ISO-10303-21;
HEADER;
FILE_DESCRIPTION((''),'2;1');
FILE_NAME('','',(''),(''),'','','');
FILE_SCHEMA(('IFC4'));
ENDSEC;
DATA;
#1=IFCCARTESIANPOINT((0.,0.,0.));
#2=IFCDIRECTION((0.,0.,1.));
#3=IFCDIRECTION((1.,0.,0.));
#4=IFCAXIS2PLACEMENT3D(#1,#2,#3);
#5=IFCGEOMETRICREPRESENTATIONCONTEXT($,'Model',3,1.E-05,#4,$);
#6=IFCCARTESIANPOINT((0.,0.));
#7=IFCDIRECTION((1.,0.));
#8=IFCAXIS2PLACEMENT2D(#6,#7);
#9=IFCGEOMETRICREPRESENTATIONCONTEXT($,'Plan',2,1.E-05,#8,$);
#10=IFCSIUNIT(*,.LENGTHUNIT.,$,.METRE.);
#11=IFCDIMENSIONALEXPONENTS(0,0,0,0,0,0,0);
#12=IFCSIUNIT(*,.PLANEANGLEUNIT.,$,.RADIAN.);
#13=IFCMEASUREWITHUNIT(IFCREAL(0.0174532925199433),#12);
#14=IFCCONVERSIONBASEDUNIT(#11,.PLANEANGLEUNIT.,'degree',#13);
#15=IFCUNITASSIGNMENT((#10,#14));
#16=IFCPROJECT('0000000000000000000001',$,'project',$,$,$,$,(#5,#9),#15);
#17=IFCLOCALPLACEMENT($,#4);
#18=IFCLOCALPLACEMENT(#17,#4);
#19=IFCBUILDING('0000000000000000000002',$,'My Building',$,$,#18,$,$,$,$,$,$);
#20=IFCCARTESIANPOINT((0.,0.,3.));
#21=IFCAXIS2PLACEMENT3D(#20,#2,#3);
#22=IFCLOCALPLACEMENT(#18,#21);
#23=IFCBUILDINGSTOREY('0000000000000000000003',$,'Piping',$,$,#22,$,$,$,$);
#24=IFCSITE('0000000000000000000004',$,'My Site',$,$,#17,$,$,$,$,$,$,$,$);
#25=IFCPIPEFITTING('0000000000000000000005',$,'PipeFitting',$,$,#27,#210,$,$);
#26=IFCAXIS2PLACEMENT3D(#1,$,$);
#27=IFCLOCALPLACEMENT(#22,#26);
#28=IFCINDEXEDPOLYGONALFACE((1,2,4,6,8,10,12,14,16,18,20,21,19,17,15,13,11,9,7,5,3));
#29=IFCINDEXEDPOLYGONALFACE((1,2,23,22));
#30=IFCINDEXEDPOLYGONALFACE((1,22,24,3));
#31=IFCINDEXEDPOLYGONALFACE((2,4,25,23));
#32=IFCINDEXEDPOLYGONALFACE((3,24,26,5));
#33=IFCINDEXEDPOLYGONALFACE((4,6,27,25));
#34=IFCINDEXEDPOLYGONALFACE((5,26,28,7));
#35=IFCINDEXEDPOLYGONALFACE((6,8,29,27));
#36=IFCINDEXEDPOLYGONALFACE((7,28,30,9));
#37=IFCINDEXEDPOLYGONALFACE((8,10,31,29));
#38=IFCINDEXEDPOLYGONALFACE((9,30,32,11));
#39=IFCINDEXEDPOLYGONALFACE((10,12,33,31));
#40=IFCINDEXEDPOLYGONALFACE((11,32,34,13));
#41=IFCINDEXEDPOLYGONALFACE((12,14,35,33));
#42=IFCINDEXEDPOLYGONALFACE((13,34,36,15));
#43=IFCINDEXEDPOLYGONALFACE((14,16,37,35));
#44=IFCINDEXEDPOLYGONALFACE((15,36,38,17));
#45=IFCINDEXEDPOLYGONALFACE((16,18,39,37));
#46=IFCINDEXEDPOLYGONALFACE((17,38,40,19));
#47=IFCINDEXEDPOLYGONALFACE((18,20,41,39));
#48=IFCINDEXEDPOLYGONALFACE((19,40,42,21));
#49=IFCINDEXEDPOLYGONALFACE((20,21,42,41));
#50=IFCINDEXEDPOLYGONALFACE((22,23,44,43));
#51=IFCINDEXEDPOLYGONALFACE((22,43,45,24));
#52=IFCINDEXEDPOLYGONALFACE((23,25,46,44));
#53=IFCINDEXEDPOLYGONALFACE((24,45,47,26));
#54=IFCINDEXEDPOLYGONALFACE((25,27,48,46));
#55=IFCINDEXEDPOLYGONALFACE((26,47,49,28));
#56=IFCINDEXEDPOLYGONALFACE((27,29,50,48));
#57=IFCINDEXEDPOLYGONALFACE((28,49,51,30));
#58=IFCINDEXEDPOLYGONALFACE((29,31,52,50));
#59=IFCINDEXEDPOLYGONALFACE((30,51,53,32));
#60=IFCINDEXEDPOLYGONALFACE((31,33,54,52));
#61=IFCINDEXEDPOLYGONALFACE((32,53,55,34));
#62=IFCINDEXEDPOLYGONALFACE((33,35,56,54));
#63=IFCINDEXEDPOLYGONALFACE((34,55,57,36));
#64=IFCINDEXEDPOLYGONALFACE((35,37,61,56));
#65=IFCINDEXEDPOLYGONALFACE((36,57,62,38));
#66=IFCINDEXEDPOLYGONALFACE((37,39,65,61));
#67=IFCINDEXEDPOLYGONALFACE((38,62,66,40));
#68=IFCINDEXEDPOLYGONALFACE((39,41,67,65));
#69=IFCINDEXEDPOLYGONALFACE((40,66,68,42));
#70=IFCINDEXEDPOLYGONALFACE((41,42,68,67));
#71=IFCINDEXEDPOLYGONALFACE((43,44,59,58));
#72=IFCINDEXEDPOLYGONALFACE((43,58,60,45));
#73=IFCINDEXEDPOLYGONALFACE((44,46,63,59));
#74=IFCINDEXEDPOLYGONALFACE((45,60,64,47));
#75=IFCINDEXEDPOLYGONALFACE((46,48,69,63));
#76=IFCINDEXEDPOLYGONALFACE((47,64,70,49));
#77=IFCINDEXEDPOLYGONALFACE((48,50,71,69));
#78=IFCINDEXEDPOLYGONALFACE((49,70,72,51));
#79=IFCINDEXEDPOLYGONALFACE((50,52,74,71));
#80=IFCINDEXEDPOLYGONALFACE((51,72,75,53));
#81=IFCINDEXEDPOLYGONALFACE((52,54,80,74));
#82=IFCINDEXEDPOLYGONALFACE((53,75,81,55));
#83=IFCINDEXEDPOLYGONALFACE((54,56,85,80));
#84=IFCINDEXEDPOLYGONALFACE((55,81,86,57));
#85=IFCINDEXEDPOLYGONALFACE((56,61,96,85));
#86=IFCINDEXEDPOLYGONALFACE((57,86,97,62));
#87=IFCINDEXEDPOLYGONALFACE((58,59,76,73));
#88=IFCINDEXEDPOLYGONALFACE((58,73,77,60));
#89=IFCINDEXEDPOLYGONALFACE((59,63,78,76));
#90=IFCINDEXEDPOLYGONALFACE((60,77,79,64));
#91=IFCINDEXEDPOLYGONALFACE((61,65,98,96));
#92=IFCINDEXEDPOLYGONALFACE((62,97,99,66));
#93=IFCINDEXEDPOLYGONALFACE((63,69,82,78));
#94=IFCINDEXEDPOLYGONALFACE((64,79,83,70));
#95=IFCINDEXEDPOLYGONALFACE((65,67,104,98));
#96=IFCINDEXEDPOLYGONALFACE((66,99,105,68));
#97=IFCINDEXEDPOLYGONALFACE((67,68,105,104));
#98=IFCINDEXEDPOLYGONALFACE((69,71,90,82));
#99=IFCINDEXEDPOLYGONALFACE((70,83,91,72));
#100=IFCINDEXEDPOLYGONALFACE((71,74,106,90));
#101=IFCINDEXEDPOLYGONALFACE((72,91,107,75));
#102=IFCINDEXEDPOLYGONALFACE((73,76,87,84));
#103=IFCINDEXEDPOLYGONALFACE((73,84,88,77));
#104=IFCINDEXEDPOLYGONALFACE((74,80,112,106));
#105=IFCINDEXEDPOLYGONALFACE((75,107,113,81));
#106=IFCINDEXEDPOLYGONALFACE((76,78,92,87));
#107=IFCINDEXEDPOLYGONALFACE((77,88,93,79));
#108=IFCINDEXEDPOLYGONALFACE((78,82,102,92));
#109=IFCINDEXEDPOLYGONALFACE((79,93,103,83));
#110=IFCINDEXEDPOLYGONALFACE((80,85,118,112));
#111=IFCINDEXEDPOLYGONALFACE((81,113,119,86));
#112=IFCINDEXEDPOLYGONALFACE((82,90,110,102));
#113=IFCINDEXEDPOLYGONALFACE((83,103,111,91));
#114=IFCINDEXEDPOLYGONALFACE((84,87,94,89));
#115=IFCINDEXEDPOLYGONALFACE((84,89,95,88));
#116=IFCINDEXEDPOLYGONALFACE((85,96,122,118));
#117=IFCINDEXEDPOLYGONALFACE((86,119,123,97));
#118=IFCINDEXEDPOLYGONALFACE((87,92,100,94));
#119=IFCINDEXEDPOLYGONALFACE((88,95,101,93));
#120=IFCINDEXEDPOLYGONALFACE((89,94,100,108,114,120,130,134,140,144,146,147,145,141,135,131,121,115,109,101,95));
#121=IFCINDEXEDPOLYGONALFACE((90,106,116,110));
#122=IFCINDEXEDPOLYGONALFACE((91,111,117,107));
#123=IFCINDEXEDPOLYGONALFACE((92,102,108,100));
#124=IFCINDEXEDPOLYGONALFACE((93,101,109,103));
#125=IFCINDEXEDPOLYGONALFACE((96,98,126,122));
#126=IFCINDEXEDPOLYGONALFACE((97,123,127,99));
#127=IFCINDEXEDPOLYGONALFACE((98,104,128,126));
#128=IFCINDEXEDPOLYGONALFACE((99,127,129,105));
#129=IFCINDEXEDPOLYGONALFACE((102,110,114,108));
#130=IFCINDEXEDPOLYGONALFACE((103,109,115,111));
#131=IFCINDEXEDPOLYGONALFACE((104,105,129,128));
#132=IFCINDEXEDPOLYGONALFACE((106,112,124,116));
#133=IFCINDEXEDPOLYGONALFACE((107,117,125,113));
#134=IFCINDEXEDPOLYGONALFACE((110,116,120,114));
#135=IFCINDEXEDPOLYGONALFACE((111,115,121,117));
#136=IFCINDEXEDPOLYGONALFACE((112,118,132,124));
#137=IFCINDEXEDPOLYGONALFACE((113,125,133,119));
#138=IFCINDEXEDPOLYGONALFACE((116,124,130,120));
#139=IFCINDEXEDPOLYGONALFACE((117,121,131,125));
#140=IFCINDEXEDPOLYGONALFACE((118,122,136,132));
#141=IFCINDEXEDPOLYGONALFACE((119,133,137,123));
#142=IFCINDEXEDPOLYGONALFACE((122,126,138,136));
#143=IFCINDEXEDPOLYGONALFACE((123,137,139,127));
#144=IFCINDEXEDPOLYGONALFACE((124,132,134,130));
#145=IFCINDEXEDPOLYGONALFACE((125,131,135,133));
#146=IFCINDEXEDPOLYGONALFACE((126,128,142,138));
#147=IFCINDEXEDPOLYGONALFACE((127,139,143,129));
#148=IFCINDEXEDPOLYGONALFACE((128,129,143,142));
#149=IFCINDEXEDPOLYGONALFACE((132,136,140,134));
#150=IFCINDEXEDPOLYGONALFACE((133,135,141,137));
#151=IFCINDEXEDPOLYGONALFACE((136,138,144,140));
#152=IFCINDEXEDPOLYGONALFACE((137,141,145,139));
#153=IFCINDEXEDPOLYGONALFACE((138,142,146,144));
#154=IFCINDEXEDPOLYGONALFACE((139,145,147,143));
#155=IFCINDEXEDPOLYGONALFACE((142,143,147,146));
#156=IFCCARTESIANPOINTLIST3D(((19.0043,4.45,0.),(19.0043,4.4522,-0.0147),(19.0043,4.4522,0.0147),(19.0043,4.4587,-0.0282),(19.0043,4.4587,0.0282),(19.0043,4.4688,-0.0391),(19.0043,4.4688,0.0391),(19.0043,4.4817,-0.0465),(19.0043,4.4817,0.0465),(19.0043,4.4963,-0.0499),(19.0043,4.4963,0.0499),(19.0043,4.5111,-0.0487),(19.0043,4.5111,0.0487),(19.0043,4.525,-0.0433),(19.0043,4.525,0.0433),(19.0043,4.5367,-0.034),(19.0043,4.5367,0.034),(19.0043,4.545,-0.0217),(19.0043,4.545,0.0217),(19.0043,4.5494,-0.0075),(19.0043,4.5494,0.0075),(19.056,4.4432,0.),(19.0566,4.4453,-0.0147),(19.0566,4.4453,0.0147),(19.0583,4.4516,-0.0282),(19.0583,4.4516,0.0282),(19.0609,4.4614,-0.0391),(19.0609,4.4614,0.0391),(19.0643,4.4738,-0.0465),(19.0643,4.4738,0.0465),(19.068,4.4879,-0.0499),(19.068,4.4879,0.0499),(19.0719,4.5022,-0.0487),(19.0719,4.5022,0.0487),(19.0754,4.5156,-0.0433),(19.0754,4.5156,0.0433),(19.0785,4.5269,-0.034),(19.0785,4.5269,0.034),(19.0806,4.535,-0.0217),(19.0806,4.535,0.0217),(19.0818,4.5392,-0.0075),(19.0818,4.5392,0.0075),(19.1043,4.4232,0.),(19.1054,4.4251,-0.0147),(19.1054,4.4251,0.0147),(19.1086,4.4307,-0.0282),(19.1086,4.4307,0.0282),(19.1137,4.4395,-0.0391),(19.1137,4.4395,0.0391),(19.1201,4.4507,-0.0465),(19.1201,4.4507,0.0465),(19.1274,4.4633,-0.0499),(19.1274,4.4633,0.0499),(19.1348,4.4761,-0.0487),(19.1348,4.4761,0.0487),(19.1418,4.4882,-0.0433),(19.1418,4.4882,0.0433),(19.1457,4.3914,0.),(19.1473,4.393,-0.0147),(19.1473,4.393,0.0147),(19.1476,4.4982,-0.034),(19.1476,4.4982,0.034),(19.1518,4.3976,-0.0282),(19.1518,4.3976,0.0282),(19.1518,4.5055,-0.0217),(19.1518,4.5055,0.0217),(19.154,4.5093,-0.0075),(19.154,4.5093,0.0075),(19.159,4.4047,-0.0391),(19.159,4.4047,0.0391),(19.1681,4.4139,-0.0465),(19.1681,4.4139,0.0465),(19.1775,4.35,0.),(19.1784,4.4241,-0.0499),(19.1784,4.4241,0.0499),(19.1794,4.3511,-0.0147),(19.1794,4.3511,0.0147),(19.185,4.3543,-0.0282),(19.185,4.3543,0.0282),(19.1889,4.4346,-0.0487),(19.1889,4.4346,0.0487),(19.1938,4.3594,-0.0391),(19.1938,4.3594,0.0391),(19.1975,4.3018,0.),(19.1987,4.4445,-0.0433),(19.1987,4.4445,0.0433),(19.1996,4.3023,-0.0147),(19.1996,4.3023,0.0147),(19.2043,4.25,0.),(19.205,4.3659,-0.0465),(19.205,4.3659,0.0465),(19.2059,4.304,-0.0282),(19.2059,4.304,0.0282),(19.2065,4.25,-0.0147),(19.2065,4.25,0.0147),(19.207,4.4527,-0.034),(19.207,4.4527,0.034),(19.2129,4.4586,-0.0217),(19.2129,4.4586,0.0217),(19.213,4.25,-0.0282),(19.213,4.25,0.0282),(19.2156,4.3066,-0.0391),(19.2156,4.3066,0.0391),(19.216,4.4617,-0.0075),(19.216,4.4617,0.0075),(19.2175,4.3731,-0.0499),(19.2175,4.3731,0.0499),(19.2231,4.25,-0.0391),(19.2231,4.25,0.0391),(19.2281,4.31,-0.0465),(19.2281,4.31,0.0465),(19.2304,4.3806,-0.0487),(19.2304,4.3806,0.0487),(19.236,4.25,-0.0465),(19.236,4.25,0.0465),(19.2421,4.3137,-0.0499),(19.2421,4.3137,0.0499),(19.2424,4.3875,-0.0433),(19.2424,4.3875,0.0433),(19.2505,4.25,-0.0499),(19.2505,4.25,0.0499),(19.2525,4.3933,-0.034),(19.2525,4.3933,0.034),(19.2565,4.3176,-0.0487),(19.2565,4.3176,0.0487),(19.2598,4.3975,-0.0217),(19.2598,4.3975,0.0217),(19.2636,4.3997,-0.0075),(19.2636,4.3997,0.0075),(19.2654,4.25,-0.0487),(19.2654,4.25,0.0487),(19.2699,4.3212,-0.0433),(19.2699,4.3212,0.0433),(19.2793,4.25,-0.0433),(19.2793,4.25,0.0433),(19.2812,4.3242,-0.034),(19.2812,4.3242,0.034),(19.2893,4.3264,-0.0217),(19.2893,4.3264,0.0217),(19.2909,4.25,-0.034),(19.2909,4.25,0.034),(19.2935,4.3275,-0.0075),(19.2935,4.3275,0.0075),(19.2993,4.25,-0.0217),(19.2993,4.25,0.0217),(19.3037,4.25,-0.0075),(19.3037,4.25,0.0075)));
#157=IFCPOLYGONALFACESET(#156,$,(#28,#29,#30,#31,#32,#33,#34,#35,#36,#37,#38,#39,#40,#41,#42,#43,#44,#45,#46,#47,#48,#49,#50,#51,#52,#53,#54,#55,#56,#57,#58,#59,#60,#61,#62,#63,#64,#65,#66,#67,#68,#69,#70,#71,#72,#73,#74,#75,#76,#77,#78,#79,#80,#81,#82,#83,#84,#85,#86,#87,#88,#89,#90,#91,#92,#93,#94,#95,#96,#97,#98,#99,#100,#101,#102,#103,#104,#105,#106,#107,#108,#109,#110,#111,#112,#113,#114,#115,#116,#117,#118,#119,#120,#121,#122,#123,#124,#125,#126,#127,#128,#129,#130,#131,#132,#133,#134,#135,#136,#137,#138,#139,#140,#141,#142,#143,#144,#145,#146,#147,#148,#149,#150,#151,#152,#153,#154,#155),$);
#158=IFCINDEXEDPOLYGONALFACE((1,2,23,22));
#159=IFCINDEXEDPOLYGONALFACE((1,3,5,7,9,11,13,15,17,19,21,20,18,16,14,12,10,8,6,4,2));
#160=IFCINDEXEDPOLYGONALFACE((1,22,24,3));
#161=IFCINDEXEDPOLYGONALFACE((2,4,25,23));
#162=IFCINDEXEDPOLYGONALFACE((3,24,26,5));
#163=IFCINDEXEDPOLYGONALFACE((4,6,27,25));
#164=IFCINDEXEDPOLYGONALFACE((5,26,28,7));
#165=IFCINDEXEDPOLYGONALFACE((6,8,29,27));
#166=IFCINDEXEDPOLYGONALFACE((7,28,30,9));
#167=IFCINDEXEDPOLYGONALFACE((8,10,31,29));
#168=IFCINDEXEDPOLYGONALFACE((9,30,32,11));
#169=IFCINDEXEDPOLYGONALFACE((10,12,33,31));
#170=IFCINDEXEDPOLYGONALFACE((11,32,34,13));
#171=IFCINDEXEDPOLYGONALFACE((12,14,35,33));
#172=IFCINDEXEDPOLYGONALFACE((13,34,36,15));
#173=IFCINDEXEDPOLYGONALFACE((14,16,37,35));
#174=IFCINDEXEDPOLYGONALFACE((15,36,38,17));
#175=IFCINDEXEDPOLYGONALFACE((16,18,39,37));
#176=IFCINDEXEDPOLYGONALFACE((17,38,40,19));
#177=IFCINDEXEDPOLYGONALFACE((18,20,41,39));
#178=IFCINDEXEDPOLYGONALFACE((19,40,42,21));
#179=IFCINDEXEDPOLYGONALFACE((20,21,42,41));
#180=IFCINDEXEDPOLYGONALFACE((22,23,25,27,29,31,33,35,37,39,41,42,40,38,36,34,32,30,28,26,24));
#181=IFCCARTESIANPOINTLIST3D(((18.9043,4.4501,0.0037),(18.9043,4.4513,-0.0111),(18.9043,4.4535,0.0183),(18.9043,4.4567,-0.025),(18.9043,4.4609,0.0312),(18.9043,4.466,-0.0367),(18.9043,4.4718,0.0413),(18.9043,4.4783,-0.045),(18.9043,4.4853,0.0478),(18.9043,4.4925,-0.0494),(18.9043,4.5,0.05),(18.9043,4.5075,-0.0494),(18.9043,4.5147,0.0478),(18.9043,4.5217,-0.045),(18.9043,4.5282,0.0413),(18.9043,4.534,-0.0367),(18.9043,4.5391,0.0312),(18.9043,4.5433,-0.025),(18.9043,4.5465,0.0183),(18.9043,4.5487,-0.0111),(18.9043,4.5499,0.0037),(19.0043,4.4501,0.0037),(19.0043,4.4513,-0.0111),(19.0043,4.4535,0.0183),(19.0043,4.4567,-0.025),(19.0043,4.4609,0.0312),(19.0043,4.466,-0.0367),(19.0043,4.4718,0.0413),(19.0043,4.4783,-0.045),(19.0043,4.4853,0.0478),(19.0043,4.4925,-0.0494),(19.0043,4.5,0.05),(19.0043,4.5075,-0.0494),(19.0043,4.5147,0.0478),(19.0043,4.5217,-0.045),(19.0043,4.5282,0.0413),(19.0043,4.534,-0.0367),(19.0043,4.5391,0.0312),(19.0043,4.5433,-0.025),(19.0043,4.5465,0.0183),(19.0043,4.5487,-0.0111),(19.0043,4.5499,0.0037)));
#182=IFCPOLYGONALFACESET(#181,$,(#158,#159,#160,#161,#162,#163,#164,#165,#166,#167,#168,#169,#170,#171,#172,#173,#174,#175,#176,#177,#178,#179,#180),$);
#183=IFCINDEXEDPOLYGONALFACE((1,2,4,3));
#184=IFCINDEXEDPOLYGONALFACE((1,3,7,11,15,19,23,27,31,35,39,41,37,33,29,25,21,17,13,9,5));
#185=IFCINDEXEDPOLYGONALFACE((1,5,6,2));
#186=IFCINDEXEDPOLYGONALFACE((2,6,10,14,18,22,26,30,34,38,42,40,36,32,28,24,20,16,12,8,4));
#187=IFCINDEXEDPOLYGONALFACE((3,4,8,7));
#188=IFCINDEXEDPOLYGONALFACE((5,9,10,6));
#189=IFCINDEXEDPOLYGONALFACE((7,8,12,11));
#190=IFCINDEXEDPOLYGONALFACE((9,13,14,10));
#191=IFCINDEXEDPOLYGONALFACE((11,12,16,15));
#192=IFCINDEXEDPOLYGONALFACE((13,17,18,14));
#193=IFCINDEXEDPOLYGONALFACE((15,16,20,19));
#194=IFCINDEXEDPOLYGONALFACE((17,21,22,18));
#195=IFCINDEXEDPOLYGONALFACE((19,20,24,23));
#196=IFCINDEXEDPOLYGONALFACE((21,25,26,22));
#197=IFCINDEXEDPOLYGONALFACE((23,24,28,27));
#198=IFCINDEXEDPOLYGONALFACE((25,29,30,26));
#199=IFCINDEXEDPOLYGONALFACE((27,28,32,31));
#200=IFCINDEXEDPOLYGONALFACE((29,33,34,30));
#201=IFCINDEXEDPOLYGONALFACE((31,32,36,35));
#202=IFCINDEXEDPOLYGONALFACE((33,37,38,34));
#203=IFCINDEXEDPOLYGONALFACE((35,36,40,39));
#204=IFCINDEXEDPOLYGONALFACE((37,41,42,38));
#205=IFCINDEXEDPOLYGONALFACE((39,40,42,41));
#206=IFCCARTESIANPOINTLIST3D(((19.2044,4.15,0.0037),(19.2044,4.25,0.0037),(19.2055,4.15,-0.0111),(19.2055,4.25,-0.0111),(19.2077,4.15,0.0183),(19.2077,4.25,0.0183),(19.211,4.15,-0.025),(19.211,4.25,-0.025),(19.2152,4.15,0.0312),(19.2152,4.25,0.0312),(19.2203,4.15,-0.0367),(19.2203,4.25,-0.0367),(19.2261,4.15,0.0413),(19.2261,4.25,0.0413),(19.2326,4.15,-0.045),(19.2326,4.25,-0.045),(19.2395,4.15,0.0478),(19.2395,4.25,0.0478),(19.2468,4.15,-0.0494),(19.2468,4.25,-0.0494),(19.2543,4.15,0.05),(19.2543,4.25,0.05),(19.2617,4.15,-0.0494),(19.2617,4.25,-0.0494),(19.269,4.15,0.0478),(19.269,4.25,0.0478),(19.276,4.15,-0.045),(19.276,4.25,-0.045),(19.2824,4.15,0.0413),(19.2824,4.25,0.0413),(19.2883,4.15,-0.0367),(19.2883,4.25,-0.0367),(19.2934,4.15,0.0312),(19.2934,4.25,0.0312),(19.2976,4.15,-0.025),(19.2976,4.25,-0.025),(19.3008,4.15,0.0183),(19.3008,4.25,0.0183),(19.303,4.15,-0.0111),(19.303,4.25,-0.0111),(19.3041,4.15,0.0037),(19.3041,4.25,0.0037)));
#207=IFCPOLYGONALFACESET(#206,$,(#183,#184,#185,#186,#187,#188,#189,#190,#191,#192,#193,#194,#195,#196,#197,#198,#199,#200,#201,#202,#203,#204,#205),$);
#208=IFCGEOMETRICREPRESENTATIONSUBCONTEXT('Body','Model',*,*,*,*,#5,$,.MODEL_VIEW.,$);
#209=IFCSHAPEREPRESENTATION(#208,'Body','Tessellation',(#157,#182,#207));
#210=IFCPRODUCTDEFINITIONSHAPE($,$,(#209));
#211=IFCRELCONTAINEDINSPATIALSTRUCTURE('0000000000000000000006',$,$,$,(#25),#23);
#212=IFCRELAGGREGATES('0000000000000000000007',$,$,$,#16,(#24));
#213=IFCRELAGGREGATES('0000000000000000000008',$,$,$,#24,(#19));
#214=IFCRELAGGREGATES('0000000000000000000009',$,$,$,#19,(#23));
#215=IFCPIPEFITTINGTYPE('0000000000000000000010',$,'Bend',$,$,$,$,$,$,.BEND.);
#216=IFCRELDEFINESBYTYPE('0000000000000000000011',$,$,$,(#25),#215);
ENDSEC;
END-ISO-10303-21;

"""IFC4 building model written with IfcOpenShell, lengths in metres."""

from ifc_helpers import new_model, entity, si_unit, converted_unit, frame, origin_with_axes, origin_2d_with_axis, place, context, subcontext, project, spatial, circle, extrude, source, transform, mapped, type_object, type_shapes, element, save


model = new_model("IFC4")

# Units and contexts
model_context = context("Model", 3, precision=1e-05, world=origin_with_axes())
plan_context = context("Plan", 2, precision=1e-05, world=origin_2d_with_axis())
body_context = subcontext(model_context, "Body", "Model", "MODEL_VIEW")
ifc_project = project(units=[si_unit("LENGTHUNIT", "METRE"), converted_unit("PLANEANGLEUNIT", "degree", entity("IfcReal", 0.0174532925199433), si_unit("PLANEANGLEUNIT", "RADIAN"), dimensions=[0, 0, 0, 0, 0, 0, 0])], contexts=[model_context, plan_context])

# Site, building, storey
site_placement = place(None, origin_with_axes())
site = spatial("IfcSite", under=ifc_project, at=site_placement, Name="My Site")
building_placement = place(site_placement, origin_with_axes())
building = spatial("IfcBuilding", under=site, at=building_placement, Name="My Building")
storey_placement = place(building_placement, frame((0.0, 0.0, 3.0), z_axis=(0.0, 0.0, 1.0), x_axis=(1.0, 0.0, 0.0)))
storey = spatial("IfcBuildingStorey", under=building, at=storey_placement, Name="Piping")

# Pipe fitting
pipe_fitting_type_1 = type_object("IfcPipeFittingType", Name="Bend", PredefinedType="BEND")
shared_shape = source(origin_with_axes(), body_context, "Body", "SolidModel", [
    entity("IfcSweptDiskSolid", entity("IfcIndexedPolyCurve", entity("IfcCartesianPointList3D", [[0.0, 0.0, -0.1], [0.0, -0.0732, -0.2768], [0.0, -0.25, -0.35]]), [entity("IfcArcIndex", [1, 2, 3])]), 0.05),
    extrude(circle(Radius=0.05), origin_with_axes(), (0.0, 0.0, -1.0), 0.1),
    extrude(circle(Radius=0.05), frame((0.0, -0.25, -0.35), z_axis=(0.0, -1.0, 0.0), x_axis=(1.0, 0.0, 0.0)), (0.0, 0.0, 1.0), 0.1),
])
type_shapes(pipe_fitting_type_1, [shared_shape])
for number, where, z_axis, x_axis, name in (
    (1, (18.9043, 4.5, 0.0), (-1.0, 0.0, 0.0), (0.0, 0.0, 1.0), "PipeFitting"),
):
    element("IfcPipeFitting", number, at=place(storey_placement, frame(where, z_axis=z_axis, x_axis=x_axis)), inside=storey, type_object=pipe_fitting_type_1, Name=name, context=body_context, shape_type="MappedRepresentation", body=[
        mapped(shared_shape, transform((0.0, 0.0, 0.0), x_axis=(1.0, 0.0, 0.0), y_axis=(0.0, 1.0, 0.0), z_axis=(0.0, 0.0, 1.0), scale=1.0)),
    ])

save(model, "model.ifc")
